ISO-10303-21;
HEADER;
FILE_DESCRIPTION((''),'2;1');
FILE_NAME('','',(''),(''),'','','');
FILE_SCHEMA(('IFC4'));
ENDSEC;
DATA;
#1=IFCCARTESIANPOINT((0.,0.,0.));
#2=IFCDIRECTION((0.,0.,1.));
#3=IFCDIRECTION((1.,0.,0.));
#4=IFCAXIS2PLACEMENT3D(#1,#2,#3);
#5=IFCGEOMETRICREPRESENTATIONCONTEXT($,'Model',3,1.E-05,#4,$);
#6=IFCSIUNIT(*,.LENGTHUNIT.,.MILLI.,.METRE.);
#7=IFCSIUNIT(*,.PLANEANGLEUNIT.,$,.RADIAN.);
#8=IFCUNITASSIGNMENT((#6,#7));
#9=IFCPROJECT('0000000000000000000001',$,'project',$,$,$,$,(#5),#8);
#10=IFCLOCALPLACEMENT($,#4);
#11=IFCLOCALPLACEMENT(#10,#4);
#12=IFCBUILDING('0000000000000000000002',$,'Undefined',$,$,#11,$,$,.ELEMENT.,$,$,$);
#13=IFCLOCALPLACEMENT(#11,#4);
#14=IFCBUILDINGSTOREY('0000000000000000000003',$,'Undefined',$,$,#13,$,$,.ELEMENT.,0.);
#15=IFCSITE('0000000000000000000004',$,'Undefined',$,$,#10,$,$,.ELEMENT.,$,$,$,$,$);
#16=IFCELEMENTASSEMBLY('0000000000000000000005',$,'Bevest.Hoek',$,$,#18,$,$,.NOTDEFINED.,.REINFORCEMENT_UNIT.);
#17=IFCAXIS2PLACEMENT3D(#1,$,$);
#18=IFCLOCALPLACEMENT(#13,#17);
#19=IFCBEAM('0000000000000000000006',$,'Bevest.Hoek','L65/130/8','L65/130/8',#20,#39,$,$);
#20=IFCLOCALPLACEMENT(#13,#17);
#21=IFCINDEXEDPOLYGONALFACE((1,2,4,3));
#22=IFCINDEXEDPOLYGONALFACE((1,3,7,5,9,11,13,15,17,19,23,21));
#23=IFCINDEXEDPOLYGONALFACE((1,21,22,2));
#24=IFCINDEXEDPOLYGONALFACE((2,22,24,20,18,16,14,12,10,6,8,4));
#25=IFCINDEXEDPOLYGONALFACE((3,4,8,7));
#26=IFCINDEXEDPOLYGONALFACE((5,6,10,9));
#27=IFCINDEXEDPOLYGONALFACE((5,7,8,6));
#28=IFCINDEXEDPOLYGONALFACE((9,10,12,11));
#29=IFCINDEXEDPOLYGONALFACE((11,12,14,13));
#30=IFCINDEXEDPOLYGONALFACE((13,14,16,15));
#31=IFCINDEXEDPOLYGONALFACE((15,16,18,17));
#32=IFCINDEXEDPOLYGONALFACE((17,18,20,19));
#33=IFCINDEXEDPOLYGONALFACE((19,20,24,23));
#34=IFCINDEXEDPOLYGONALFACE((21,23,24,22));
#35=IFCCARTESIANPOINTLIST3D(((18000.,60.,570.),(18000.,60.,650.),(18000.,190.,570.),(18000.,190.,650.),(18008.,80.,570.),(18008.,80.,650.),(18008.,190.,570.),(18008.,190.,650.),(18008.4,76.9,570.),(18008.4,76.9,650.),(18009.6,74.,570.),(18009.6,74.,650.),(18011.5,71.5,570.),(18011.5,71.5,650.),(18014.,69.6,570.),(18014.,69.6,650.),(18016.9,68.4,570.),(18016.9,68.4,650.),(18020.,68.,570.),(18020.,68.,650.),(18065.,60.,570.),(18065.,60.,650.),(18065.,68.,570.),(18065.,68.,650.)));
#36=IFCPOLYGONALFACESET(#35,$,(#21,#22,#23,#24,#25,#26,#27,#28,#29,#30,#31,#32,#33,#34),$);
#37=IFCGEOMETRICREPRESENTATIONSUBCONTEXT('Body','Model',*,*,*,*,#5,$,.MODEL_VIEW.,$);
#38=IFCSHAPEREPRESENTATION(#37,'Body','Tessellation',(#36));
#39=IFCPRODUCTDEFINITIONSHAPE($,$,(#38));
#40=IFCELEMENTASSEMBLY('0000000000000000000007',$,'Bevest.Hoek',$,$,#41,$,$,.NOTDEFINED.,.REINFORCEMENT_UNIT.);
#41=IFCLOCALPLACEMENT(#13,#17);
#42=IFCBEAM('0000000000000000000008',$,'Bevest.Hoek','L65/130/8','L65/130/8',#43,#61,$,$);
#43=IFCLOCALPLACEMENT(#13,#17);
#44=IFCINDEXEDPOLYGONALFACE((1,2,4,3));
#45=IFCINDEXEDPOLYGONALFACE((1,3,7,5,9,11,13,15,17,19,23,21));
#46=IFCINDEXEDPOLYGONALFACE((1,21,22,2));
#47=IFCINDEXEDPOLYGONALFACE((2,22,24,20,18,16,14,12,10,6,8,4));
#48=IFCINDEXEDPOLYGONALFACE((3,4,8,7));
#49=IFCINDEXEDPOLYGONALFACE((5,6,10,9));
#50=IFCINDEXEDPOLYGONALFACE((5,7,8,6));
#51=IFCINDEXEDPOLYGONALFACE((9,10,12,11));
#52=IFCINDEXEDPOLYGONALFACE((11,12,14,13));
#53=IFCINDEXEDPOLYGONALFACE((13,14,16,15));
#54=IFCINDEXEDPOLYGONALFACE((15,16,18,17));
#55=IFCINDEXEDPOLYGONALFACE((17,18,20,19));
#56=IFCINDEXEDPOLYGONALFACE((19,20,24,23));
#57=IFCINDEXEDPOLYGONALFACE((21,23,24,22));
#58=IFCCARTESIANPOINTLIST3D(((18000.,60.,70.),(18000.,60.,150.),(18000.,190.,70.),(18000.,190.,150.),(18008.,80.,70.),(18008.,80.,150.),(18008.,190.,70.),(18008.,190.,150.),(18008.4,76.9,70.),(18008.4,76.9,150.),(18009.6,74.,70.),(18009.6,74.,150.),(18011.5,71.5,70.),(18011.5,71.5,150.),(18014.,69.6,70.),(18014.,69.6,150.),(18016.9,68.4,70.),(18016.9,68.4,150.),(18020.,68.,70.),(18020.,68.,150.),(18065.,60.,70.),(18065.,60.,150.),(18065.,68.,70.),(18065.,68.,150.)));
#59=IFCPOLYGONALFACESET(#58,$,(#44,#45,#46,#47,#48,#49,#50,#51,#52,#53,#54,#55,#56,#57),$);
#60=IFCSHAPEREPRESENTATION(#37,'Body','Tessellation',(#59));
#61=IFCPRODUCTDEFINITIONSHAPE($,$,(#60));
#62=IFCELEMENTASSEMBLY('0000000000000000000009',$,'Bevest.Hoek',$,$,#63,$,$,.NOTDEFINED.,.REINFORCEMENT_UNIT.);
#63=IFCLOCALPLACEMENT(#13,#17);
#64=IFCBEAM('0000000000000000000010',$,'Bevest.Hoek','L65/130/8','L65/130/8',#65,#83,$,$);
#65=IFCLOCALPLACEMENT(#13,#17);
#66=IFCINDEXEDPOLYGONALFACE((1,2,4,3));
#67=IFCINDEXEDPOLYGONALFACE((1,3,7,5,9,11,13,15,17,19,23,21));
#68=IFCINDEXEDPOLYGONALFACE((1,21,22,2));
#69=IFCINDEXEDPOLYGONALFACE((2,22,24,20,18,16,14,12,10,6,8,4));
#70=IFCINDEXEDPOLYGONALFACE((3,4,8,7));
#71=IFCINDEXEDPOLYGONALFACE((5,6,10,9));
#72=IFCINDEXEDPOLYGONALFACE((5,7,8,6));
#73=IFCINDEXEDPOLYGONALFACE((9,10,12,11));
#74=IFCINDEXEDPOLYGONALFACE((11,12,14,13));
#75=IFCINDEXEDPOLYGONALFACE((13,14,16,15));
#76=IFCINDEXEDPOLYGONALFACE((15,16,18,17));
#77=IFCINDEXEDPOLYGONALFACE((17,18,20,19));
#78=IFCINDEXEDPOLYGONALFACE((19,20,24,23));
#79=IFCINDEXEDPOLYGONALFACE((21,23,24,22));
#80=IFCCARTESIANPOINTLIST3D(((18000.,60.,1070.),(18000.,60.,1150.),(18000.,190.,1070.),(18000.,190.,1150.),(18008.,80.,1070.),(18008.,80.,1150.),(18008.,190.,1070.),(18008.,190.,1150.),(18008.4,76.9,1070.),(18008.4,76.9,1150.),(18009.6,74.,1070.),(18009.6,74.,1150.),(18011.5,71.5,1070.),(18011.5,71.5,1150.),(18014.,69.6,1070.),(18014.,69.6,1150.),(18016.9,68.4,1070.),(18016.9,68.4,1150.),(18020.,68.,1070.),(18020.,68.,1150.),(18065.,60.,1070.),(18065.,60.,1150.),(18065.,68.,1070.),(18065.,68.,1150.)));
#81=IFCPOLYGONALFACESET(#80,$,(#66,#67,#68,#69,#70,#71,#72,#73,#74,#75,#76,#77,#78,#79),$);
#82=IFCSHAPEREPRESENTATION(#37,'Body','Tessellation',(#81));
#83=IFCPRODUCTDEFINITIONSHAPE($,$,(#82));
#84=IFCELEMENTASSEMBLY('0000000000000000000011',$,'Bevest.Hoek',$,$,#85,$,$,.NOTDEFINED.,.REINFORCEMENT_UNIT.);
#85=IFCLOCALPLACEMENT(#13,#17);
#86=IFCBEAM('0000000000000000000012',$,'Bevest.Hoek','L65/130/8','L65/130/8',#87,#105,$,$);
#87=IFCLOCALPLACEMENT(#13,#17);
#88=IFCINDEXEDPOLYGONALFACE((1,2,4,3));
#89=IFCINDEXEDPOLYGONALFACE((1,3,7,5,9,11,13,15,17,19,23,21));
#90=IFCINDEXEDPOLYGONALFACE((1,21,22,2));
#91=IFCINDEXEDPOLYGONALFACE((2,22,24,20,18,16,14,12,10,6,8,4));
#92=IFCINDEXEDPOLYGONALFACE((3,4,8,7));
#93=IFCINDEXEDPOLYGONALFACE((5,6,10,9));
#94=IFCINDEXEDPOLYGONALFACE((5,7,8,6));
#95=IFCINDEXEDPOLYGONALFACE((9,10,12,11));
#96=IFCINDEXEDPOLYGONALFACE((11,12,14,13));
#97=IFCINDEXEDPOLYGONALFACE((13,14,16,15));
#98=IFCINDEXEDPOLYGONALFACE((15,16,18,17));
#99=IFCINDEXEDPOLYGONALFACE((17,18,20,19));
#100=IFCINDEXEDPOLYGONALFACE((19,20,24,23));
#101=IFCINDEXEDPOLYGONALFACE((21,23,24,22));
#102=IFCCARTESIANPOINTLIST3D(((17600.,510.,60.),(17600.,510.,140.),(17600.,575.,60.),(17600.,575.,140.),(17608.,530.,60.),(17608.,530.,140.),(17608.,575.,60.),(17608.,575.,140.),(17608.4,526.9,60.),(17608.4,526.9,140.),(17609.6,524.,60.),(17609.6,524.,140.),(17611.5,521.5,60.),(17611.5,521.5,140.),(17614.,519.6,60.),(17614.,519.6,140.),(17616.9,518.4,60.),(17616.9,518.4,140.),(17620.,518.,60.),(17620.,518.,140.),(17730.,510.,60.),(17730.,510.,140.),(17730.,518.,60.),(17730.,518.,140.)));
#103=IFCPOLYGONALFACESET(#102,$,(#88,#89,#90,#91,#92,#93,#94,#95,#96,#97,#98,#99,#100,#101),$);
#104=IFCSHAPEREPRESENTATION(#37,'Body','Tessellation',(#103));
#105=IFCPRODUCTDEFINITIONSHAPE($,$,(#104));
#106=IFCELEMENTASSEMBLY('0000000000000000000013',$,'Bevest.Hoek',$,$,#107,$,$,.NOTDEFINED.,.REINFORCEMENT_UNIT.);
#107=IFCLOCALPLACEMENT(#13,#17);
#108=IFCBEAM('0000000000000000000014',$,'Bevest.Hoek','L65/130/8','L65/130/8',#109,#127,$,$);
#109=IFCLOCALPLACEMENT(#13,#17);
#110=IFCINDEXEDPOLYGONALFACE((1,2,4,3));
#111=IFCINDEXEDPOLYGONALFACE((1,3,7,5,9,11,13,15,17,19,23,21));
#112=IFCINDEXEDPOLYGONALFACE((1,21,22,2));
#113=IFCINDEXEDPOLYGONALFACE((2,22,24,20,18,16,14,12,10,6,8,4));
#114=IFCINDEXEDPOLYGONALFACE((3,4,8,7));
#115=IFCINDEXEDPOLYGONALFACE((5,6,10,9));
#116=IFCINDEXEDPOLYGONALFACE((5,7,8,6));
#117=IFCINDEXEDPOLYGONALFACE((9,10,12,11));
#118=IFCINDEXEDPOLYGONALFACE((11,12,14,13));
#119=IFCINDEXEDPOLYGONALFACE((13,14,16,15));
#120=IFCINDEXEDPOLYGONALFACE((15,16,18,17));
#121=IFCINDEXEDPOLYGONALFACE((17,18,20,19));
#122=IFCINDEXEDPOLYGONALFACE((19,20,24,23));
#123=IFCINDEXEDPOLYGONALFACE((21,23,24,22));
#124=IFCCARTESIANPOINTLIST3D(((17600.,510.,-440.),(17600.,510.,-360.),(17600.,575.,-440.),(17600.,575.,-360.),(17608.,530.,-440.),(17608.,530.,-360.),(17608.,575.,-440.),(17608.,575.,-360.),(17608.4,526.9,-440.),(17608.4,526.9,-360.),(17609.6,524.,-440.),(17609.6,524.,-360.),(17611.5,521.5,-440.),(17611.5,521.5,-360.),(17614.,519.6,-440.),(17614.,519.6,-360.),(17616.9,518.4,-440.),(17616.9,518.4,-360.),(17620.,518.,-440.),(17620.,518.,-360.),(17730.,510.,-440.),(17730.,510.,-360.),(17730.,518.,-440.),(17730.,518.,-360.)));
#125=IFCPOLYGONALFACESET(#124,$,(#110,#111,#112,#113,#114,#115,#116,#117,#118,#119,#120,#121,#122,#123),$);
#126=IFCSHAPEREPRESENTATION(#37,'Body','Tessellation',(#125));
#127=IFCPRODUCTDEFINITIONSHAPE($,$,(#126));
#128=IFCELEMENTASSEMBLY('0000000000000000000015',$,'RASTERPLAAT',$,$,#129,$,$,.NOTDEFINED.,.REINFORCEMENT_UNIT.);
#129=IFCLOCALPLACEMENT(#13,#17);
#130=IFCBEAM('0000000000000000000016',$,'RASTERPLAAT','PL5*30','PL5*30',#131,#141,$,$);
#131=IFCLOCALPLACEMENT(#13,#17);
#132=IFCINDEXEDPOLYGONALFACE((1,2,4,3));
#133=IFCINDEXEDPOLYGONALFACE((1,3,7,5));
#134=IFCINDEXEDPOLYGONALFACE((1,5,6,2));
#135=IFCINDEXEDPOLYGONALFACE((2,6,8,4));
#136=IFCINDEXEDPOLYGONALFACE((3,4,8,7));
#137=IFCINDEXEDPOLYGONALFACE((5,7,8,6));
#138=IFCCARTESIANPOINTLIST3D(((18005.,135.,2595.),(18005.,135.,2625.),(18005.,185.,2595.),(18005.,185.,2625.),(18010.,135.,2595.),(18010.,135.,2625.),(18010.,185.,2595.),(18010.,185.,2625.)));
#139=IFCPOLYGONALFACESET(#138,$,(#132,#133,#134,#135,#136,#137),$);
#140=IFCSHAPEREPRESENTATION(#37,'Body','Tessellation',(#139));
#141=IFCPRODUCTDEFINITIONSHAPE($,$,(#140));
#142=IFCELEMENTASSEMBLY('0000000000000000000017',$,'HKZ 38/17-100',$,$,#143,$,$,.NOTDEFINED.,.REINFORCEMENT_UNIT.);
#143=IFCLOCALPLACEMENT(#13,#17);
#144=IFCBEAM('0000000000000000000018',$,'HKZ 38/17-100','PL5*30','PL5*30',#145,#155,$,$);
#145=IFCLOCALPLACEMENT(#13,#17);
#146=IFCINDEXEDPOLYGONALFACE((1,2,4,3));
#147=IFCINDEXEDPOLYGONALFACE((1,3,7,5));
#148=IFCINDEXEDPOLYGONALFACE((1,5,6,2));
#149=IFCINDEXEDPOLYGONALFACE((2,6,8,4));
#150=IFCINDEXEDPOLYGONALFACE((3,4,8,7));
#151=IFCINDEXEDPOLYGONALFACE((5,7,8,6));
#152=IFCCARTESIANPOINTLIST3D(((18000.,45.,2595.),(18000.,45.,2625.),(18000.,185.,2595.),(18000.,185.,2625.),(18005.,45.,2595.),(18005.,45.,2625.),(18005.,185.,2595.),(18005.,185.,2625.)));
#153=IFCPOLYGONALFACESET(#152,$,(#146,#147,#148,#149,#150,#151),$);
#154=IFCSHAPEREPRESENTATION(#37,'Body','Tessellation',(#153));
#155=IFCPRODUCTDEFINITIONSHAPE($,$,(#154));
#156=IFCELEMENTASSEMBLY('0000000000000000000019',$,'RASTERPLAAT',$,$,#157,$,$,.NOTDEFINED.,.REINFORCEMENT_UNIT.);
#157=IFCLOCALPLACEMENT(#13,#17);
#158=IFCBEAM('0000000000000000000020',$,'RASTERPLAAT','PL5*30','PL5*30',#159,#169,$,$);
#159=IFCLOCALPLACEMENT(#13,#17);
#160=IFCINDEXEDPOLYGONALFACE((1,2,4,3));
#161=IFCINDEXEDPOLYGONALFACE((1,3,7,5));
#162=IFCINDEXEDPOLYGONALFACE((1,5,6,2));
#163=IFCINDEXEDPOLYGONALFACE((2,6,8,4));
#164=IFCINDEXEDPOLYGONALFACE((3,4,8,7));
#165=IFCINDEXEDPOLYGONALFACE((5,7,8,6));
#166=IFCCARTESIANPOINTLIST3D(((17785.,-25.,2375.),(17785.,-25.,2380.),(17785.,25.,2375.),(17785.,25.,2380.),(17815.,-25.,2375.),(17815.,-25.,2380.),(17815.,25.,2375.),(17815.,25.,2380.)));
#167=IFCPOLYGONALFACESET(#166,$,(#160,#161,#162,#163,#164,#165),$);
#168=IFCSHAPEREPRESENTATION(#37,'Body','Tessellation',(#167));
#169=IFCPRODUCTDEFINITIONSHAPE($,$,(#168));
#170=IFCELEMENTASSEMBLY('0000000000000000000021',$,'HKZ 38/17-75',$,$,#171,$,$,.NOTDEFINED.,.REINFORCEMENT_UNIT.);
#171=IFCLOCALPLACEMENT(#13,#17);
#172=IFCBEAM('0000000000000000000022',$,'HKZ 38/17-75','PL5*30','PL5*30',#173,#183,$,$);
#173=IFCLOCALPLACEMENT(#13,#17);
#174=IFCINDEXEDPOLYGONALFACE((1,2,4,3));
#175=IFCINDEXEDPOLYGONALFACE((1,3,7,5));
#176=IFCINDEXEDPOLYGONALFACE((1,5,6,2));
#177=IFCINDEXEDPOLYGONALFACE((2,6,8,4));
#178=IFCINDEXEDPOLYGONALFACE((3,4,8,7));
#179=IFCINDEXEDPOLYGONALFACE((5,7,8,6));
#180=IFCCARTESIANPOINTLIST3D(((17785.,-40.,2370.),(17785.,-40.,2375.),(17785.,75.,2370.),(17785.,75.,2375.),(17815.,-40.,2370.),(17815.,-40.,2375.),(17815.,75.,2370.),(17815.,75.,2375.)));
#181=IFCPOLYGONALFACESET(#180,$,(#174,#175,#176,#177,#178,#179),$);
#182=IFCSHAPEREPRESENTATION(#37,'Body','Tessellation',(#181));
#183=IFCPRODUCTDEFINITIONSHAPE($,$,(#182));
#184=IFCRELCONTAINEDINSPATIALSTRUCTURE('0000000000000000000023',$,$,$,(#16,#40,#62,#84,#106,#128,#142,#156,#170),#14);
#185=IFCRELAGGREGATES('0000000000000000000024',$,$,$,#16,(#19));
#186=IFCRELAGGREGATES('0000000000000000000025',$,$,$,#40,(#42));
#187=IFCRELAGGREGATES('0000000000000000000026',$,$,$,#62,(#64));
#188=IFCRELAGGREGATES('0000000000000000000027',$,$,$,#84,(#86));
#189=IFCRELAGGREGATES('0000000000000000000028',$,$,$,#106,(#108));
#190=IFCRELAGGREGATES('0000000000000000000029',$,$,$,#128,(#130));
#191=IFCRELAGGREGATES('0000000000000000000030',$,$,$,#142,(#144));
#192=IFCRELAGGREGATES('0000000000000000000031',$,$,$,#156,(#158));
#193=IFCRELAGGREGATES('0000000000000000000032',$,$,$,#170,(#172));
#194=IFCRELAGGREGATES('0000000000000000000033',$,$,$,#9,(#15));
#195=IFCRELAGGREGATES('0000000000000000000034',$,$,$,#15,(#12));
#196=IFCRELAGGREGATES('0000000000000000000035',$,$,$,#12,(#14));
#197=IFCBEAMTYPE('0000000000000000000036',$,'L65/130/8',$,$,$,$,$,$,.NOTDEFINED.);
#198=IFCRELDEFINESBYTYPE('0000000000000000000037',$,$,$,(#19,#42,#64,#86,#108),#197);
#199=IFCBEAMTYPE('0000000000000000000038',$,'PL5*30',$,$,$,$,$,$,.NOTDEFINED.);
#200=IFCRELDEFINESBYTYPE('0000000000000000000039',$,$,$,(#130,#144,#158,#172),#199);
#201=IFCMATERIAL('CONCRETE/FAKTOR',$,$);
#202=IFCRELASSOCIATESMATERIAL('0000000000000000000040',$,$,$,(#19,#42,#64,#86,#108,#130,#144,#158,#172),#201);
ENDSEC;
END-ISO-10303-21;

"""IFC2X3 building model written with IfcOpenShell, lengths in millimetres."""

from ifc_helpers import new_model, si_unit, frame, frame_2d, origin_with_axes, place, context, subcontext, project, spatial, rectangle, l_section, extrude, material, type_object, element, aggregate, save


model = new_model("IFC2X3")

# Units and contexts
model_context = context("Model", 3, precision=1e-05, world=origin_with_axes())
body_context = subcontext(model_context, "Body", "Model", "MODEL_VIEW")
ifc_project = project(units=[si_unit("LENGTHUNIT", "METRE", prefix="MILLI"), si_unit("PLANEANGLEUNIT", "RADIAN")], contexts=[model_context])

# Site, building, storey
site_placement = place(None, origin_with_axes())
site = spatial("IfcSite", under=ifc_project, at=site_placement, Name="Undefined", CompositionType="ELEMENT")
building_placement = place(site_placement, origin_with_axes())
building = spatial("IfcBuilding", under=site, at=building_placement, Name="Undefined", CompositionType="ELEMENT")
storey_placement = place(building_placement, origin_with_axes())
storey = spatial("IfcBuildingStorey", under=building, at=storey_placement, Name="Undefined", CompositionType="ELEMENT", Elevation=0.0)

# Element assemblies, beams
ifc_material_1 = material(Name="CONCRETE/FAKTOR")
beam_type_1 = type_object("IfcBeamType", Name="L65/130/8", PredefinedType="NOTDEFINED")
assembly_1_placement = place(storey_placement, origin_with_axes())
assembly_1 = element("IfcElementAssembly", 1, at=assembly_1_placement, inside=storey, Name="Bevest.Hoek", AssemblyPlace="NOTDEFINED", PredefinedType="REINFORCEMENT_UNIT")
beam_1_placement = place(assembly_1_placement, frame((18032.5, 125.0, 570.0), z_axis=(1.0, 0.0, 0.0), x_axis=(0.0, 0.0, 1.0)))
beam_1 = element("IfcBeam", 2, at=beam_1_placement, type_object=beam_type_1, material=ifc_material_1, Name="Bevest.Hoek", Description="L65/130/8", ObjectType="L65/130/8", context=body_context, shape_type="SweptSolid", body=[
    extrude(l_section(Depth=65.0, Width=130.0, Thickness=8.0, FilletRadius=12.0, at=frame_2d((0.0, 0.0), x_axis=(1.0, 0.0))), frame((80.0, 0.0, 0.0), z_axis=(-1.0, 0.0, 0.0), x_axis=(0.0, -1.0, 0.0)), (0.0, 0.0, 1.0), 80.0),
])
aggregate(assembly_1, [beam_1])
assembly_2_placement = place(storey_placement, origin_with_axes())
assembly_2 = element("IfcElementAssembly", 3, at=assembly_2_placement, inside=storey, Name="Bevest.Hoek", AssemblyPlace="NOTDEFINED", PredefinedType="REINFORCEMENT_UNIT")
beam_2_placement = place(assembly_2_placement, frame((18032.5, 125.0, 70.0), z_axis=(1.0, 0.0, 0.0), x_axis=(0.0, 0.0, 1.0)))
beam_2 = element("IfcBeam", 4, at=beam_2_placement, type_object=beam_type_1, material=ifc_material_1, Name="Bevest.Hoek", Description="L65/130/8", ObjectType="L65/130/8", context=body_context, shape_type="SweptSolid", body=[
    extrude(l_section(Depth=65.0, Width=130.0, Thickness=8.0, FilletRadius=12.0, at=frame_2d((0.0, 0.0), x_axis=(1.0, 0.0))), frame((80.0, 0.0, 0.0), z_axis=(-1.0, 0.0, 0.0), x_axis=(0.0, -1.0, 0.0)), (0.0, 0.0, 1.0), 80.0),
])
aggregate(assembly_2, [beam_2])
assembly_3_placement = place(storey_placement, origin_with_axes())
assembly_3 = element("IfcElementAssembly", 5, at=assembly_3_placement, inside=storey, Name="Bevest.Hoek", AssemblyPlace="NOTDEFINED", PredefinedType="REINFORCEMENT_UNIT")
beam_3_placement = place(assembly_3_placement, frame((18032.5, 125.0, 1070.0), z_axis=(1.0, 0.0, 0.0), x_axis=(0.0, 0.0, 1.0)))
beam_3 = element("IfcBeam", 6, at=beam_3_placement, type_object=beam_type_1, material=ifc_material_1, Name="Bevest.Hoek", Description="L65/130/8", ObjectType="L65/130/8", context=body_context, shape_type="SweptSolid", body=[
    extrude(l_section(Depth=65.0, Width=130.0, Thickness=8.0, FilletRadius=12.0, at=frame_2d((0.0, 0.0), x_axis=(1.0, 0.0))), frame((80.0, 0.0, 0.0), z_axis=(-1.0, 0.0, 0.0), x_axis=(0.0, -1.0, 0.0)), (0.0, 0.0, 1.0), 80.0),
])
aggregate(assembly_3, [beam_3])
assembly_4_placement = place(storey_placement, origin_with_axes())
assembly_4 = element("IfcElementAssembly", 7, at=assembly_4_placement, inside=storey, Name="Bevest.Hoek", AssemblyPlace="NOTDEFINED", PredefinedType="REINFORCEMENT_UNIT")
beam_4_placement = place(assembly_4_placement, frame((17665.0, 542.5, 140.0), z_axis=(0.0, 1.0, 0.0), x_axis=(0.0, 0.0, -1.0)))
beam_4 = element("IfcBeam", 8, at=beam_4_placement, type_object=beam_type_1, material=ifc_material_1, Name="Bevest.Hoek", Description="L65/130/8", ObjectType="L65/130/8", context=body_context, shape_type="SweptSolid", body=[
    extrude(l_section(Depth=65.0, Width=130.0, Thickness=8.0, FilletRadius=12.0, at=frame_2d((0.0, 0.0), x_axis=(1.0, 0.0))), frame((80.0, 0.0, 0.0), z_axis=(-1.0, 0.0, 0.0), x_axis=(0.0, -1.0, 0.0)), (0.0, 0.0, 1.0), 80.0),
])
aggregate(assembly_4, [beam_4])
assembly_5_placement = place(storey_placement, origin_with_axes())
assembly_5 = element("IfcElementAssembly", 9, at=assembly_5_placement, inside=storey, Name="Bevest.Hoek", AssemblyPlace="NOTDEFINED", PredefinedType="REINFORCEMENT_UNIT")
beam_5_placement = place(assembly_5_placement, frame((17665.0, 542.5, -360.0), z_axis=(0.0, 1.0, 0.0), x_axis=(0.0, 0.0, -1.0)))
beam_5 = element("IfcBeam", 10, at=beam_5_placement, type_object=beam_type_1, material=ifc_material_1, Name="Bevest.Hoek", Description="L65/130/8", ObjectType="L65/130/8", context=body_context, shape_type="SweptSolid", body=[
    extrude(l_section(Depth=65.0, Width=130.0, Thickness=8.0, FilletRadius=12.0, at=frame_2d((0.0, 0.0), x_axis=(1.0, 0.0))), frame((80.0, 0.0, 0.0), z_axis=(-1.0, 0.0, 0.0), x_axis=(0.0, -1.0, 0.0)), (0.0, 0.0, 1.0), 80.0),
])
aggregate(assembly_5, [beam_5])
assembly_6_placement = place(storey_placement, origin_with_axes())
assembly_6 = element("IfcElementAssembly", 11, at=assembly_6_placement, inside=storey, Name="RASTERPLAAT", AssemblyPlace="NOTDEFINED", PredefinedType="REINFORCEMENT_UNIT")
beam_type_2 = type_object("IfcBeamType", Name="PL5*30", PredefinedType="NOTDEFINED")
beam_6_placement = place(assembly_6_placement, frame((18007.5, 185.0, 2610.0), z_axis=(0.0, 0.0, 1.0), x_axis=(0.0, -1.0, 0.0)))
beam_6 = element("IfcBeam", 12, at=beam_6_placement, type_object=beam_type_2, material=ifc_material_1, Name="RASTERPLAAT", Description="PL5*30", ObjectType="PL5*30", context=body_context, shape_type="SweptSolid", body=[
    extrude(rectangle(XDim=5.0, YDim=30.0, at=frame_2d((0.0, 0.0), x_axis=(1.0, 0.0))), frame((50.0, 0.0, 0.0), z_axis=(-1.0, 0.0, 0.0), x_axis=(0.0, -1.0, 0.0)), (0.0, 0.0, 1.0), 50.0),
])
aggregate(assembly_6, [beam_6])
assembly_7_placement = place(storey_placement, origin_with_axes())
assembly_7 = element("IfcElementAssembly", 13, at=assembly_7_placement, inside=storey, Name="HKZ 38/17-100", AssemblyPlace="NOTDEFINED", PredefinedType="REINFORCEMENT_UNIT")
beam_7_placement = place(assembly_7_placement, frame((18002.5, 45.0, 2610.0), z_axis=(0.0, 0.0, 1.0), x_axis=(0.0, 1.0, 0.0)))
beam_7 = element("IfcBeam", 14, at=beam_7_placement, type_object=beam_type_2, material=ifc_material_1, Name="HKZ 38/17-100", Description="PL5*30", ObjectType="PL5*30", context=body_context, shape_type="SweptSolid", body=[
    extrude(rectangle(XDim=5.0, YDim=30.0, at=frame_2d((0.0, 0.0), x_axis=(1.0, 0.0))), frame((140.0, 0.0, 0.0), z_axis=(-1.0, 0.0, 0.0), x_axis=(0.0, -1.0, 0.0)), (0.0, 0.0, 1.0), 140.0),
])
aggregate(assembly_7, [beam_7])
assembly_8_placement = place(storey_placement, origin_with_axes())
assembly_8 = element("IfcElementAssembly", 15, at=assembly_8_placement, inside=storey, Name="RASTERPLAAT", AssemblyPlace="NOTDEFINED", PredefinedType="REINFORCEMENT_UNIT")
beam_8_placement = place(assembly_8_placement, frame((17800.0, 25.0, 2377.5), z_axis=(-1.0, 0.0, 0.0), x_axis=(0.0, -1.0, 0.0)))
beam_8 = element("IfcBeam", 16, at=beam_8_placement, type_object=beam_type_2, material=ifc_material_1, Name="RASTERPLAAT", Description="PL5*30", ObjectType="PL5*30", context=body_context, shape_type="SweptSolid", body=[
    extrude(rectangle(XDim=5.0, YDim=30.0, at=frame_2d((0.0, 0.0), x_axis=(1.0, 0.0))), frame((50.0, 0.0, 0.0), z_axis=(-1.0, 0.0, 0.0), x_axis=(0.0, -1.0, 0.0)), (0.0, 0.0, 1.0), 50.0),
])
aggregate(assembly_8, [beam_8])
assembly_9_placement = place(storey_placement, origin_with_axes())
assembly_9 = element("IfcElementAssembly", 17, at=assembly_9_placement, inside=storey, Name="HKZ 38/17-75", AssemblyPlace="NOTDEFINED", PredefinedType="REINFORCEMENT_UNIT")
beam_9_placement = place(assembly_9_placement, frame((17800.0, 75.0, 2372.5), z_axis=(-1.0, 0.0, 0.0), x_axis=(0.0, -1.0, 0.0)))
beam_9 = element("IfcBeam", 18, at=beam_9_placement, type_object=beam_type_2, material=ifc_material_1, Name="HKZ 38/17-75", Description="PL5*30", ObjectType="PL5*30", context=body_context, shape_type="SweptSolid", body=[
    extrude(rectangle(XDim=5.0, YDim=30.0, at=frame_2d((0.0, 0.0), x_axis=(1.0, 0.0))), frame((115.0, 0.0, 0.0), z_axis=(-1.0, 0.0, 0.0), x_axis=(0.0, -1.0, 0.0)), (0.0, 0.0, 1.0), 115.0),
])
aggregate(assembly_9, [beam_9])

save(model, "model.ifc")
